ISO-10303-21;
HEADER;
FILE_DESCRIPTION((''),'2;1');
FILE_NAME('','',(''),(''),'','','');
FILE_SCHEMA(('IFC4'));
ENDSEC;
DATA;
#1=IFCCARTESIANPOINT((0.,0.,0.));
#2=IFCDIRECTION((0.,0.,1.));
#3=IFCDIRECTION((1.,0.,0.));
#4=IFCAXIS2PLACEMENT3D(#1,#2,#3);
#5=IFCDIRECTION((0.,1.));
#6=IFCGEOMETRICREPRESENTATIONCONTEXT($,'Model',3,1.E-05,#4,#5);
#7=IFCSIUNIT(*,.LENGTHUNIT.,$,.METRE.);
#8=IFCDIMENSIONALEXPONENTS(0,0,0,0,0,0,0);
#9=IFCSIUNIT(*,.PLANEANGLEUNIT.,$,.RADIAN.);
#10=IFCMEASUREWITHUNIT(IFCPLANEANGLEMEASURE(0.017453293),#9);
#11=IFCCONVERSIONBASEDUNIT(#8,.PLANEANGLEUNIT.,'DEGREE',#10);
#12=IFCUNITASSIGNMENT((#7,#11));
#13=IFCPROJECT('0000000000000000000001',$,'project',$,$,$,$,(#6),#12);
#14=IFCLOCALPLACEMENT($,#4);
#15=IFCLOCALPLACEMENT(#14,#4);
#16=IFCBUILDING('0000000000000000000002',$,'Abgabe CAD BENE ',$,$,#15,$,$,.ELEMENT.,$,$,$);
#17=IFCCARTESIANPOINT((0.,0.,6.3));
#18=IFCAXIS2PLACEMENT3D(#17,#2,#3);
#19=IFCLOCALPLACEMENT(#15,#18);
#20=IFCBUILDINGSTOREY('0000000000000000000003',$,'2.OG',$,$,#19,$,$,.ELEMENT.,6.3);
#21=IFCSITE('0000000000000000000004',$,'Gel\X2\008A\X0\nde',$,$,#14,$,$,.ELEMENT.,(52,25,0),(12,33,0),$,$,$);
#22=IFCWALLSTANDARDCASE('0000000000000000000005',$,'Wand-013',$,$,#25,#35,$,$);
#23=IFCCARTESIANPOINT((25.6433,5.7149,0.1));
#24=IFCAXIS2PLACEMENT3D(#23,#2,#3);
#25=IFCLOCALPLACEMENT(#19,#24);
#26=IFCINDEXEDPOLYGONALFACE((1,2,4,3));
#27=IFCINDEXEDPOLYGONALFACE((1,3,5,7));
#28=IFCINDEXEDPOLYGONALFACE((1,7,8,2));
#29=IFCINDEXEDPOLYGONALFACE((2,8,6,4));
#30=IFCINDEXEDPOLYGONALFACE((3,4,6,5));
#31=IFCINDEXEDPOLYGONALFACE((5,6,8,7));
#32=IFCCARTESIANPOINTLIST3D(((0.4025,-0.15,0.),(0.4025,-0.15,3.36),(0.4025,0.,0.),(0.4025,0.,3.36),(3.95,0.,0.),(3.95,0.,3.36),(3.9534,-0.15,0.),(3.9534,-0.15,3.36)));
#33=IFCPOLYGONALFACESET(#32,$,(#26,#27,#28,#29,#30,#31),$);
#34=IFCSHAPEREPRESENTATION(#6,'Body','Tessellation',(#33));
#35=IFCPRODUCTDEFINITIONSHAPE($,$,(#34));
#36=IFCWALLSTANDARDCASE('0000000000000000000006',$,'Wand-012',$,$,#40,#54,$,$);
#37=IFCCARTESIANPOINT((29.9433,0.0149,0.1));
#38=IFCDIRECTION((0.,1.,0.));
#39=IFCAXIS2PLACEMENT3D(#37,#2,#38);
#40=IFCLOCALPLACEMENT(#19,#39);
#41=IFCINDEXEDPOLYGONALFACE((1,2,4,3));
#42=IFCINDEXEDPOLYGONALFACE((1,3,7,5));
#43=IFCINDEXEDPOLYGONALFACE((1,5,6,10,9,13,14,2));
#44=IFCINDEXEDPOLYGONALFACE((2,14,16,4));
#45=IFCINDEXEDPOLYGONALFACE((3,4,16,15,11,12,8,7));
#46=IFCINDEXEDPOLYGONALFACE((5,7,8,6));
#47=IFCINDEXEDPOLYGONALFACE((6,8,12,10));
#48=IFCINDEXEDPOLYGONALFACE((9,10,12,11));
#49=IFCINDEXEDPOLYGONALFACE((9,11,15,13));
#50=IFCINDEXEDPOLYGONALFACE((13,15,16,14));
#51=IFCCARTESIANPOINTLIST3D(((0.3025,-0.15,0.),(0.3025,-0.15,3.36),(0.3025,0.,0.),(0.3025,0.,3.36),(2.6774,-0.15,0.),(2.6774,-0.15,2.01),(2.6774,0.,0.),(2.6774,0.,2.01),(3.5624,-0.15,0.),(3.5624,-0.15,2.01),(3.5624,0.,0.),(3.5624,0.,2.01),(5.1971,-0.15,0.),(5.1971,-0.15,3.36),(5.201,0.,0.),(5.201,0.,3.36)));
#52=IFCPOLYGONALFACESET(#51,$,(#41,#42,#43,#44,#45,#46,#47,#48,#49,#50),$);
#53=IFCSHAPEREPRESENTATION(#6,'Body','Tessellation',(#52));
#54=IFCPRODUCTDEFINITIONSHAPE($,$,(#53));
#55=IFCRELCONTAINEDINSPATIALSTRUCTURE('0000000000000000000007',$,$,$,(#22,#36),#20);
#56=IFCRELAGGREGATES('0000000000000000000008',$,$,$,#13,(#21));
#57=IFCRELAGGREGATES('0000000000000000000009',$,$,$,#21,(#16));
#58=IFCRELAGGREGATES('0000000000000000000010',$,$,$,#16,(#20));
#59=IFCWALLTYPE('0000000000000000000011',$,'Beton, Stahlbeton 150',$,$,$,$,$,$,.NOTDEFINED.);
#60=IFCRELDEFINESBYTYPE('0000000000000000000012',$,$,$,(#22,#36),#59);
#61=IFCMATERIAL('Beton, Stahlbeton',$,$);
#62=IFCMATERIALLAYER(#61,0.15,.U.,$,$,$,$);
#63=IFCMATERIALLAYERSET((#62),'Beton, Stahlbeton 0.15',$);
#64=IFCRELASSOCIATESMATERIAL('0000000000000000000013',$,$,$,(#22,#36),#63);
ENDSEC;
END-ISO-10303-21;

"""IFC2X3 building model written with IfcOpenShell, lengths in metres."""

from ifc_helpers import new_model, entity, si_unit, converted_unit, direction, frame, origin_with_axes, origin_2d_with_axis, place, context, project, spatial, polyline, rectangle, outline, extrude, material, layer, layer_set, layer_usage, type_object, element, save


model = new_model("IFC2X3")

# Units and contexts
model_context = context("Model", 3, precision=1e-05, world=origin_with_axes(), true_north=direction((0.0, 1.0)))
ifc_project = project(units=[si_unit("LENGTHUNIT", "METRE"), converted_unit("PLANEANGLEUNIT", "DEGREE", entity("IfcPlaneAngleMeasure", 0.017453293), si_unit("PLANEANGLEUNIT", "RADIAN"), dimensions=[0, 0, 0, 0, 0, 0, 0])], contexts=[model_context])

# Site, building, storey
site_placement = place(None, origin_with_axes())
site = spatial("IfcSite", under=ifc_project, at=site_placement, Name="Gel\u008ande", CompositionType="ELEMENT", RefLatitude=(52, 25, 0), RefLongitude=(12, 33, 0))
building_placement = place(site_placement, origin_with_axes())
building = spatial("IfcBuilding", under=site, at=building_placement, Name="Abgabe CAD BENE ", CompositionType="ELEMENT")
storey_placement = place(building_placement, frame((0.0, 0.0, 6.3), z_axis=(0.0, 0.0, 1.0), x_axis=(1.0, 0.0, 0.0)))
storey = spatial("IfcBuildingStorey", under=building, at=storey_placement, Name="2.OG", CompositionType="ELEMENT", Elevation=6.3)

# Wall
ifc_material_1 = material(Name="Beton, Stahlbeton")
ifc_layer_1 = layer(ifc_material_1, 0.15, ventilated="UNKNOWN")
ifc_layer_set_1 = layer_set([ifc_layer_1], Name="Beton, Stahlbeton 0.15")
ifc_layer_usage_1 = layer_usage(ifc_layer_set_1, "AXIS2", "NEGATIVE", 0.0)
wall_type_1 = type_object("IfcWallType", Name="Beton, Stahlbeton 150", PredefinedType="NOTDEFINED")
wall_1_placement = place(storey_placement, frame((25.6433, 5.7149, 0.1), z_axis=(0.0, 0.0, 1.0), x_axis=(1.0, 0.0, 0.0)))
element("IfcWallStandardCase", 1, at=wall_1_placement, inside=storey, type_object=wall_type_1, material=ifc_layer_usage_1, Name="Wand-013", context=model_context, shape_type="SweptSolid", body=[
    extrude(outline(polyline([(0.4025, -0.15), (3.9534, -0.15), (3.95, 0.0), (0.4025, 0.0), (0.4025, -0.15)])), origin_with_axes(), (0.0, 0.0, 1.0), 3.36),
])

# Wall, opening
ifc_layer_usage_2 = layer_usage(ifc_layer_set_1, "AXIS2", "NEGATIVE", 0.0)
wall_2_placement = place(storey_placement, frame((29.9433, 0.0149, 0.1), z_axis=(0.0, 0.0, 1.0), x_axis=(0.0, 1.0, 0.0)))
wall_2 = element("IfcWallStandardCase", 2, at=wall_2_placement, inside=storey, type_object=wall_type_1, material=ifc_layer_usage_2, Name="Wand-012", context=model_context, shape_type="SweptSolid", body=[
    extrude(outline(polyline([(0.3025, -0.15), (5.1971, -0.15), (5.201, 0.0), (0.3025, 0.0), (0.3025, -0.15)])), origin_with_axes(), (0.0, 0.0, 1.0), 3.36),
])
opening_1_placement = place(wall_2_placement, frame((3.1199, 0.0, 0.0), z_axis=(0.0, 0.0, 1.0), x_axis=(1.0, 0.0, 0.0)))
element("IfcOpeningElement", 3, at=opening_1_placement, cuts=wall_2, context=model_context, shape_type="SweptSolid", body=[
    extrude(rectangle(XDim=0.885, YDim=2.01, at=origin_2d_with_axis()), frame((0.0, 0.001, 1.005), z_axis=(0.0, -1.0, 0.0), x_axis=(1.0, 0.0, 0.0)), (0.0, 0.0, 1.0), 0.452),
])

save(model, "model.ifc")
